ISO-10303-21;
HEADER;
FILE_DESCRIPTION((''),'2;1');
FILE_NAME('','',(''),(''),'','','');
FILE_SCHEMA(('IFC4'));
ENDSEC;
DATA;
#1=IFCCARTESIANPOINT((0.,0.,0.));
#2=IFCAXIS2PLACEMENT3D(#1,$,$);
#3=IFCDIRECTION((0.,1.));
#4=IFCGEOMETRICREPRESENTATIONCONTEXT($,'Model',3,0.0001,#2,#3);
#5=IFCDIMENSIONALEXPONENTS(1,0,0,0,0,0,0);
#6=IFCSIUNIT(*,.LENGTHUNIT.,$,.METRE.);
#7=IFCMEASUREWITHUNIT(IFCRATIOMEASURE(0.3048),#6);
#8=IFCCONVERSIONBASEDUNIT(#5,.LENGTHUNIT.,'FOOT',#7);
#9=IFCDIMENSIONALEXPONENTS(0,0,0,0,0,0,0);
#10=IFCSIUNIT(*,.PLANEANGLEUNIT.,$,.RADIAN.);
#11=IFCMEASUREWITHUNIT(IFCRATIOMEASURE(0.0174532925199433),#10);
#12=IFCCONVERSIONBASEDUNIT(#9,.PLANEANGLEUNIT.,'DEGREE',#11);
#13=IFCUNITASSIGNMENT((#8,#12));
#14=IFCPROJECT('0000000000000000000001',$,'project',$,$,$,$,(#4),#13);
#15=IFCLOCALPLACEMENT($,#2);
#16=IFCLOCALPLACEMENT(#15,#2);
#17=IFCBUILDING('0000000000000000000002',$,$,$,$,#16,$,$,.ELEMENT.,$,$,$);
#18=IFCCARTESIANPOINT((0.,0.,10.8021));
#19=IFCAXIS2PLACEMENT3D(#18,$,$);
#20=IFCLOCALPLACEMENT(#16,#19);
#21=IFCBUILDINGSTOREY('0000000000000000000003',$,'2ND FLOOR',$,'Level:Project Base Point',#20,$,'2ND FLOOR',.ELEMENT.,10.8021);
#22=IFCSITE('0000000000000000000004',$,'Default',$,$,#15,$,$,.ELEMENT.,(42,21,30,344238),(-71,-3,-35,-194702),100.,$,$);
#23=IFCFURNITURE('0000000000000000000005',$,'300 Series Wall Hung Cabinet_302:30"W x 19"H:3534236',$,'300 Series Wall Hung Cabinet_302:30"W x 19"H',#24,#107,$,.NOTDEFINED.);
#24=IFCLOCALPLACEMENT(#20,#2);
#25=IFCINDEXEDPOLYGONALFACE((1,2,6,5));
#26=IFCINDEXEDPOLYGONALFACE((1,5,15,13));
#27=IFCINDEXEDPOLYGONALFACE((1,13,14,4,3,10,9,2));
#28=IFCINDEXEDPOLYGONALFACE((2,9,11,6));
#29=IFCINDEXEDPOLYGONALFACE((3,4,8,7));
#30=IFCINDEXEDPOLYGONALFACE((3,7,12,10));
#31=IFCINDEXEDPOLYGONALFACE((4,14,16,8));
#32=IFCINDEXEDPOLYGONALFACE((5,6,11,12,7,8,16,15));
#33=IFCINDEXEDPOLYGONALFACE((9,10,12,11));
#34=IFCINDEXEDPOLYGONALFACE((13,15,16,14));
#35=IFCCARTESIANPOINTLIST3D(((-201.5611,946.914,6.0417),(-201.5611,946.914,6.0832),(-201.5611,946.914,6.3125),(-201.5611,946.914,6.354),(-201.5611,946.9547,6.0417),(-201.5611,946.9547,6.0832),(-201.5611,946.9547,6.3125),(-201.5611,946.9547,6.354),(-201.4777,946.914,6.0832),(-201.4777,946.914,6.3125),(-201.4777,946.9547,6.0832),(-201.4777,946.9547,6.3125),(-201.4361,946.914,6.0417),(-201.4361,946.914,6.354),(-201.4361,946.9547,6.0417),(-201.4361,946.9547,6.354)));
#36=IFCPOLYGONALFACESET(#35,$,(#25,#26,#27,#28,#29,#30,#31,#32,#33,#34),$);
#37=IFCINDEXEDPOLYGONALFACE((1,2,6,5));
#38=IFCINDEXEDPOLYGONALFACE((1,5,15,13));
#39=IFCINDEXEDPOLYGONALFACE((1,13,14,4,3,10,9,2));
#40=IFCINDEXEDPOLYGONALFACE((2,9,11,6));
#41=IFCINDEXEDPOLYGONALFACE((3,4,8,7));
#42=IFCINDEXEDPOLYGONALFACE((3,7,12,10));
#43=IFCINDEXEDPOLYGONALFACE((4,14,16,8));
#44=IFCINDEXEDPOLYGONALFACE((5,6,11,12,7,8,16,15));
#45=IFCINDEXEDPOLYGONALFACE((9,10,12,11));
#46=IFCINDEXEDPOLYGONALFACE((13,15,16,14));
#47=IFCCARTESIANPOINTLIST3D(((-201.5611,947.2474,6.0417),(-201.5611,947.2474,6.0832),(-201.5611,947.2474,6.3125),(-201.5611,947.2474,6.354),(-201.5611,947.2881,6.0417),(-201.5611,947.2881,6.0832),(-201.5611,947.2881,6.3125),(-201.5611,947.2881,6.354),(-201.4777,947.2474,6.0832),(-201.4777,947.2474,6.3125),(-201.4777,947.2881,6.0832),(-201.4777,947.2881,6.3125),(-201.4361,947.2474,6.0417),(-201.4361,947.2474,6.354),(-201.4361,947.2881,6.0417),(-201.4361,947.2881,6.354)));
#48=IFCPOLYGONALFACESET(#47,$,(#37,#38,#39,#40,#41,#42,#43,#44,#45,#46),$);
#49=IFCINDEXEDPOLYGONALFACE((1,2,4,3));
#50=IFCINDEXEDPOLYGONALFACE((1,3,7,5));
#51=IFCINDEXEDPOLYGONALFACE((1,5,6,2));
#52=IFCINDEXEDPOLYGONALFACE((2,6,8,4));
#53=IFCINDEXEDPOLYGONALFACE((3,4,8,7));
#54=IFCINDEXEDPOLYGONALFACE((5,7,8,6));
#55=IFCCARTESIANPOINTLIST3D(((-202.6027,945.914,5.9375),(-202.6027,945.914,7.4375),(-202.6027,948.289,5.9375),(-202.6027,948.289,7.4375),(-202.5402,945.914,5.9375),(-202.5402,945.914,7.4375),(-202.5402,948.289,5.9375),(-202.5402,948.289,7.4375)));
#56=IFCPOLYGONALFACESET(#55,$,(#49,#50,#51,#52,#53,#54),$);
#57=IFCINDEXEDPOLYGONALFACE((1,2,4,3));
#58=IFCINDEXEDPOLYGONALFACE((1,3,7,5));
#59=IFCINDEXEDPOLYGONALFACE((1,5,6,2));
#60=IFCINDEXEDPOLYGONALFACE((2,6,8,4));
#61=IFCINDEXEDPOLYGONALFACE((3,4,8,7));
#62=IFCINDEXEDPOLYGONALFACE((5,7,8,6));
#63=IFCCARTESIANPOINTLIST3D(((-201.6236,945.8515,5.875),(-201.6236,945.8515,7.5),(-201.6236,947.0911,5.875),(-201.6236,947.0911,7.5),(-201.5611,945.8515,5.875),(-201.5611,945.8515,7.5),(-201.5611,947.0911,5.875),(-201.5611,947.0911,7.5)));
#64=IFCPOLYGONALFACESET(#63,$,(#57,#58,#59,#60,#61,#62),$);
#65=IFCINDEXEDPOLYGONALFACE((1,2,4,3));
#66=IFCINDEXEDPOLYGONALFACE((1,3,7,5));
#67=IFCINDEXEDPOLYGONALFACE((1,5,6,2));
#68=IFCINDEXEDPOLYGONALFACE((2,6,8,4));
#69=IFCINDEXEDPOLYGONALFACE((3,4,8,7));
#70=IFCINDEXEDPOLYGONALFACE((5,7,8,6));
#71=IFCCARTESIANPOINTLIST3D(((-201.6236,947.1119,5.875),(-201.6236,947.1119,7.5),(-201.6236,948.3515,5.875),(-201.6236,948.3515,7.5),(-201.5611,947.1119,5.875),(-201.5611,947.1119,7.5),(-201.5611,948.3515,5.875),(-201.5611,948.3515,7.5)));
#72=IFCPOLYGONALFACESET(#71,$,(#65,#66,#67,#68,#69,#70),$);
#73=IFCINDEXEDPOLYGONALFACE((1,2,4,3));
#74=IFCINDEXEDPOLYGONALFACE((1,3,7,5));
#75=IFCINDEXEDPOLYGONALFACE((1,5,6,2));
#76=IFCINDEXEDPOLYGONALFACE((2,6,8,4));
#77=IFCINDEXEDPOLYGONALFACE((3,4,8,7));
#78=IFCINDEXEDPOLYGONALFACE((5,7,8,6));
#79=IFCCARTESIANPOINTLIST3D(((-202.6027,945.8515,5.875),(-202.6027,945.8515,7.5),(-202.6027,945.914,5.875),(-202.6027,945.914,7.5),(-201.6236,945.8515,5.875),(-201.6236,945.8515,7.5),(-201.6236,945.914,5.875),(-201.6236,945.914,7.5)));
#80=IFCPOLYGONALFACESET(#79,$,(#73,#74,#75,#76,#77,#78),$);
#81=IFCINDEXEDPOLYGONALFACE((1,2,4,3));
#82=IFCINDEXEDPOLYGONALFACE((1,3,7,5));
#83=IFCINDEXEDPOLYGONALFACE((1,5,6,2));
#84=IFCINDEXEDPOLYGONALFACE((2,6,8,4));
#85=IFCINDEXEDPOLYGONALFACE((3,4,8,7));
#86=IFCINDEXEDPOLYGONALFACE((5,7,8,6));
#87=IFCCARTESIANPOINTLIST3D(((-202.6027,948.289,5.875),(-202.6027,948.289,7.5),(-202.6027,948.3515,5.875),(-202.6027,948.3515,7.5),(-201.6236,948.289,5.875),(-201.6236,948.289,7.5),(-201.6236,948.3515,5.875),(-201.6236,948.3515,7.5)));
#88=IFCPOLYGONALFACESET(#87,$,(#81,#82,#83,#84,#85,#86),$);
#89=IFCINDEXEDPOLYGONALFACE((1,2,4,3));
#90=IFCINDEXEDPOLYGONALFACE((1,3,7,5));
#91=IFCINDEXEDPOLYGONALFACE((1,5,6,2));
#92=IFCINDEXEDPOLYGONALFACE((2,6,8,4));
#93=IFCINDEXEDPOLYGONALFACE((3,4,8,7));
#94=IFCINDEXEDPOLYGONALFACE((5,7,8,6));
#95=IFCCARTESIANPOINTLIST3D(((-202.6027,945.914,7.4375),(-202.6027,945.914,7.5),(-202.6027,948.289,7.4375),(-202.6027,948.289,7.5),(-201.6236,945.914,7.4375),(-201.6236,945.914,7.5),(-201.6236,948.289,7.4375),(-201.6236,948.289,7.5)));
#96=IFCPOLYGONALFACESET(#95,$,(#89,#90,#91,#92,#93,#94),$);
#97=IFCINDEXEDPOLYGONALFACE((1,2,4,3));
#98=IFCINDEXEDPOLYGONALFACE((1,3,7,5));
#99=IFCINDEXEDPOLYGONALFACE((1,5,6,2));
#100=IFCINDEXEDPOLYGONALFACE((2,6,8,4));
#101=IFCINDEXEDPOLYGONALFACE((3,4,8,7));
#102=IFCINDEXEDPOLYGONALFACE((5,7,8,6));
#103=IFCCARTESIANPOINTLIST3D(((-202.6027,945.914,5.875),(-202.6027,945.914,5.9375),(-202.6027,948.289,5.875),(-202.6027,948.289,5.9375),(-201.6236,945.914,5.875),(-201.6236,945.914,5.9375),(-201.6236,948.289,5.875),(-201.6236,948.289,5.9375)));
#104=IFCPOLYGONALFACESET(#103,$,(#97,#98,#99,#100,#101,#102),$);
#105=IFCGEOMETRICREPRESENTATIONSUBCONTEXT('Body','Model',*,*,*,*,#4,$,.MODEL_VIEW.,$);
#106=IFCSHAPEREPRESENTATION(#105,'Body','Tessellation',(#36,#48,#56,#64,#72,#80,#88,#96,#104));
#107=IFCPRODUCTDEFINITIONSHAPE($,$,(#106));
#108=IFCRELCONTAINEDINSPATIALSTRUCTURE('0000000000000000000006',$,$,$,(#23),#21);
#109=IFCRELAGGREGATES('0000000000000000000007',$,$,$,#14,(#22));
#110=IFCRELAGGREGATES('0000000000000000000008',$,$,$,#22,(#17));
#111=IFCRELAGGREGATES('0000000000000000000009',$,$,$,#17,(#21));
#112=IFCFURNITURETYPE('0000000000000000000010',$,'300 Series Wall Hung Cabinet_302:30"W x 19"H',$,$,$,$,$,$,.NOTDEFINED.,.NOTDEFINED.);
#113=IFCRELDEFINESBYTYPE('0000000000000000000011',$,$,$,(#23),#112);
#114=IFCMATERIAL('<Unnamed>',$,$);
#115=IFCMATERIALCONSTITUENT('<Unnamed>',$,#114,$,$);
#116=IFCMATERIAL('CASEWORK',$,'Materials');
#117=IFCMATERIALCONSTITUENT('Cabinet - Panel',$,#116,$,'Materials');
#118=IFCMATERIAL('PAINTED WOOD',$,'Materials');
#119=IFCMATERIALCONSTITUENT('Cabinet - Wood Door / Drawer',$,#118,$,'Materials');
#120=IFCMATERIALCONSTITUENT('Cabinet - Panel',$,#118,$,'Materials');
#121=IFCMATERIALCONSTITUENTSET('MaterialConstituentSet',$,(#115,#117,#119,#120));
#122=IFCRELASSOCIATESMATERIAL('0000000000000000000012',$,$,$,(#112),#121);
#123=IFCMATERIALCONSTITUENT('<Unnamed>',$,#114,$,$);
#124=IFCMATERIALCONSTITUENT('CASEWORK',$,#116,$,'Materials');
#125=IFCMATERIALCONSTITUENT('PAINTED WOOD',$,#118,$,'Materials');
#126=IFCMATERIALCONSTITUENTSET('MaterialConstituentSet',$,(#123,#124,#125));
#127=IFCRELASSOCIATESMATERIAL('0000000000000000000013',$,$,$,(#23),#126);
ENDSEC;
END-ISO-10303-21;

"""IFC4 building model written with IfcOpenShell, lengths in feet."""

from ifc_helpers import new_model, entity, si_unit, converted_unit, direction, frame, frame_2d, origin, origin_2d_with_axis, place, context, subcontext, project, spatial, polyline, rectangle, outline, extrude, source, transform, mapped, material, constituent, constituent_set, type_object, type_shapes, element, save


model = new_model("IFC4")

# Units and contexts
model_context = context("Model", 3, precision=0.0001, world=origin(), true_north=direction((0.0, 1.0)))
body_context = subcontext(model_context, "Body", "Model", "MODEL_VIEW")
ifc_project = project(units=[converted_unit("LENGTHUNIT", "FOOT", entity("IfcRatioMeasure", 0.3048), si_unit("LENGTHUNIT", "METRE"), dimensions=[1, 0, 0, 0, 0, 0, 0]), converted_unit("PLANEANGLEUNIT", "DEGREE", entity("IfcRatioMeasure", 0.0174532925199433), si_unit("PLANEANGLEUNIT", "RADIAN"), dimensions=[0, 0, 0, 0, 0, 0, 0])], contexts=[model_context])

# Site, building, storey
site_placement = place(None, origin())
site = spatial("IfcSite", under=ifc_project, at=site_placement, Name="Default", CompositionType="ELEMENT", RefLatitude=(42, 21, 30, 344238), RefLongitude=(-71, -3, -35, -194702), RefElevation=100.0)
building_placement = place(site_placement, origin())
building = spatial("IfcBuilding", under=site, at=building_placement, CompositionType="ELEMENT")
storey_placement = place(building_placement, frame((0.0, 0.0, 10.8021)))
storey = spatial("IfcBuildingStorey", under=building, at=storey_placement, Name="2ND FLOOR", ObjectType="Level:Project Base Point", LongName="2ND FLOOR", CompositionType="ELEMENT", Elevation=10.8021)

# Furniture
ifc_material_1 = material(Name="CASEWORK", Category="Materials")
ifc_material_2 = material(Name="PAINTED WOOD", Category="Materials")
ifc_material_3 = material(Name="<Unnamed>")
ifc_constituent_1 = constituent(ifc_material_3, Name="<Unnamed>")
ifc_constituent_2 = constituent(ifc_material_1, Name="CASEWORK", Category="Materials")
ifc_constituent_3 = constituent(ifc_material_2, Name="PAINTED WOOD", Category="Materials")
ifc_constituent_set_1 = constituent_set(constituents=[ifc_constituent_1, ifc_constituent_2, ifc_constituent_3], Name="MaterialConstituentSet")
ifc_constituent_4 = constituent(ifc_material_3, Name="<Unnamed>")
ifc_constituent_5 = constituent(ifc_material_1, Name="Cabinet - Panel", Category="Materials")
ifc_constituent_6 = constituent(ifc_material_2, Name="Cabinet - Wood Door / Drawer", Category="Materials")
ifc_constituent_7 = constituent(ifc_material_2, Name="Cabinet - Panel", Category="Materials")
ifc_constituent_set_2 = constituent_set(constituents=[ifc_constituent_4, ifc_constituent_5, ifc_constituent_6, ifc_constituent_7], Name="MaterialConstituentSet")
furniture_type_1 = type_object("IfcFurnitureType", Name="300 Series Wall Hung Cabinet_302:30\"W x 19\"H", AssemblyPlace="NOTDEFINED", PredefinedType="NOTDEFINED", material=ifc_constituent_set_2)
shared_shape_1 = source(origin(), body_context, "Body", "SweptSolid", [
    extrude(outline(polyline([(0.1146, -0.0521), (0.1562, -0.0521), (0.1562, 0.0729), (-0.1562, 0.0729), (-0.1562, -0.0521), (-0.1146, -0.0521), (-0.1146, 0.0313), (0.1146, 0.0313), (0.1146, -0.0521)])), frame((1.0625, 0.0729, 0.3229), z_axis=(1.0, 0.0, 0.0), x_axis=(0.0, 0.0, 1.0)), (0.0, 0.0, 1.0), 0.0407),
    extrude(outline(polyline([(0.1146, -0.0521), (0.1562, -0.0521), (0.1562, 0.0729), (-0.1562, 0.0729), (-0.1562, -0.0521), (-0.1146, -0.0521), (-0.1146, 0.0313), (0.1146, 0.0313), (0.1146, -0.0521)])), frame((1.3958, 0.0729, 0.3229), z_axis=(1.0, 0.0, 0.0), x_axis=(0.0, 0.0, 1.0)), (0.0, 0.0, 1.0), 0.0407),
    extrude(rectangle(XDim=2.375, YDim=0.0625, at=origin_2d_with_axis()), frame((1.25, 1.1354, 0.0625), z_axis=(0.0, 0.0, 1.0), x_axis=(-1.0, 0.0, 0.0)), (0.0, 0.0, 1.0), 1.5),
    extrude(rectangle(XDim=1.2396, YDim=0.0625, at=origin_2d_with_axis()), frame((0.6198, 0.1562, 0.0), z_axis=(0.0, 0.0, 1.0), x_axis=(-1.0, 0.0, 0.0)), (0.0, 0.0, 1.0), 1.625),
    extrude(rectangle(XDim=1.2396, YDim=0.0625, at=frame_2d((0.0, 0.0), x_axis=(1.0, 0.0))), frame((1.8802, 0.1562, 0.0), z_axis=(0.0, 0.0, 1.0), x_axis=(-1.0, 0.0, 0.0)), (0.0, 0.0, 1.0), 1.625),
    extrude(rectangle(XDim=0.9792, YDim=0.0625, at=frame_2d((0.0, 0.0), x_axis=(1.0, 0.0))), frame((0.0313, 0.677, 0.0), z_axis=(0.0, 0.0, 1.0), x_axis=(0.0, -1.0, 0.0)), (0.0, 0.0, 1.0), 1.625),
    extrude(rectangle(XDim=0.9792, YDim=0.0625, at=frame_2d((0.0, 0.0), x_axis=(1.0, 0.0))), frame((2.4688, 0.677, 0.0), z_axis=(0.0, 0.0, 1.0), x_axis=(0.0, -1.0, 0.0)), (0.0, 0.0, 1.0), 1.625),
    extrude(rectangle(XDim=0.9792, YDim=2.375, at=frame_2d((0.0, 0.0), x_axis=(1.0, 0.0))), frame((1.25, 0.677, 1.5625), z_axis=(0.0, 0.0, 1.0), x_axis=(0.0, 1.0, 0.0)), (0.0, 0.0, 1.0), 0.0625),
    extrude(rectangle(XDim=0.9792, YDim=2.375, at=frame_2d((0.0, 0.0), x_axis=(1.0, 0.0))), frame((1.25, 0.677, 0.0), z_axis=(0.0, 0.0, 1.0), x_axis=(0.0, 1.0, 0.0)), (0.0, 0.0, 1.0), 0.0625),
])
type_shapes(furniture_type_1, [shared_shape_1])
furniture_1_placement = place(storey_placement, frame((-201.4361, 945.8515, 5.875), z_axis=(0.0, 0.0, 1.0), x_axis=(0.0, 1.0, 0.0)))
element("IfcFurniture", 1, at=furniture_1_placement, inside=storey, type_object=furniture_type_1, material=ifc_constituent_set_1, Name="300 Series Wall Hung Cabinet_302:30\"W x 19\"H:3534236", ObjectType="300 Series Wall Hung Cabinet_302:30\"W x 19\"H", PredefinedType="NOTDEFINED", context=body_context, shape_type="MappedRepresentation", body=[
    mapped(shared_shape_1, transform((0.0, 0.0, 0.0), scale=1.0)),
])

save(model, "model.ifc")
